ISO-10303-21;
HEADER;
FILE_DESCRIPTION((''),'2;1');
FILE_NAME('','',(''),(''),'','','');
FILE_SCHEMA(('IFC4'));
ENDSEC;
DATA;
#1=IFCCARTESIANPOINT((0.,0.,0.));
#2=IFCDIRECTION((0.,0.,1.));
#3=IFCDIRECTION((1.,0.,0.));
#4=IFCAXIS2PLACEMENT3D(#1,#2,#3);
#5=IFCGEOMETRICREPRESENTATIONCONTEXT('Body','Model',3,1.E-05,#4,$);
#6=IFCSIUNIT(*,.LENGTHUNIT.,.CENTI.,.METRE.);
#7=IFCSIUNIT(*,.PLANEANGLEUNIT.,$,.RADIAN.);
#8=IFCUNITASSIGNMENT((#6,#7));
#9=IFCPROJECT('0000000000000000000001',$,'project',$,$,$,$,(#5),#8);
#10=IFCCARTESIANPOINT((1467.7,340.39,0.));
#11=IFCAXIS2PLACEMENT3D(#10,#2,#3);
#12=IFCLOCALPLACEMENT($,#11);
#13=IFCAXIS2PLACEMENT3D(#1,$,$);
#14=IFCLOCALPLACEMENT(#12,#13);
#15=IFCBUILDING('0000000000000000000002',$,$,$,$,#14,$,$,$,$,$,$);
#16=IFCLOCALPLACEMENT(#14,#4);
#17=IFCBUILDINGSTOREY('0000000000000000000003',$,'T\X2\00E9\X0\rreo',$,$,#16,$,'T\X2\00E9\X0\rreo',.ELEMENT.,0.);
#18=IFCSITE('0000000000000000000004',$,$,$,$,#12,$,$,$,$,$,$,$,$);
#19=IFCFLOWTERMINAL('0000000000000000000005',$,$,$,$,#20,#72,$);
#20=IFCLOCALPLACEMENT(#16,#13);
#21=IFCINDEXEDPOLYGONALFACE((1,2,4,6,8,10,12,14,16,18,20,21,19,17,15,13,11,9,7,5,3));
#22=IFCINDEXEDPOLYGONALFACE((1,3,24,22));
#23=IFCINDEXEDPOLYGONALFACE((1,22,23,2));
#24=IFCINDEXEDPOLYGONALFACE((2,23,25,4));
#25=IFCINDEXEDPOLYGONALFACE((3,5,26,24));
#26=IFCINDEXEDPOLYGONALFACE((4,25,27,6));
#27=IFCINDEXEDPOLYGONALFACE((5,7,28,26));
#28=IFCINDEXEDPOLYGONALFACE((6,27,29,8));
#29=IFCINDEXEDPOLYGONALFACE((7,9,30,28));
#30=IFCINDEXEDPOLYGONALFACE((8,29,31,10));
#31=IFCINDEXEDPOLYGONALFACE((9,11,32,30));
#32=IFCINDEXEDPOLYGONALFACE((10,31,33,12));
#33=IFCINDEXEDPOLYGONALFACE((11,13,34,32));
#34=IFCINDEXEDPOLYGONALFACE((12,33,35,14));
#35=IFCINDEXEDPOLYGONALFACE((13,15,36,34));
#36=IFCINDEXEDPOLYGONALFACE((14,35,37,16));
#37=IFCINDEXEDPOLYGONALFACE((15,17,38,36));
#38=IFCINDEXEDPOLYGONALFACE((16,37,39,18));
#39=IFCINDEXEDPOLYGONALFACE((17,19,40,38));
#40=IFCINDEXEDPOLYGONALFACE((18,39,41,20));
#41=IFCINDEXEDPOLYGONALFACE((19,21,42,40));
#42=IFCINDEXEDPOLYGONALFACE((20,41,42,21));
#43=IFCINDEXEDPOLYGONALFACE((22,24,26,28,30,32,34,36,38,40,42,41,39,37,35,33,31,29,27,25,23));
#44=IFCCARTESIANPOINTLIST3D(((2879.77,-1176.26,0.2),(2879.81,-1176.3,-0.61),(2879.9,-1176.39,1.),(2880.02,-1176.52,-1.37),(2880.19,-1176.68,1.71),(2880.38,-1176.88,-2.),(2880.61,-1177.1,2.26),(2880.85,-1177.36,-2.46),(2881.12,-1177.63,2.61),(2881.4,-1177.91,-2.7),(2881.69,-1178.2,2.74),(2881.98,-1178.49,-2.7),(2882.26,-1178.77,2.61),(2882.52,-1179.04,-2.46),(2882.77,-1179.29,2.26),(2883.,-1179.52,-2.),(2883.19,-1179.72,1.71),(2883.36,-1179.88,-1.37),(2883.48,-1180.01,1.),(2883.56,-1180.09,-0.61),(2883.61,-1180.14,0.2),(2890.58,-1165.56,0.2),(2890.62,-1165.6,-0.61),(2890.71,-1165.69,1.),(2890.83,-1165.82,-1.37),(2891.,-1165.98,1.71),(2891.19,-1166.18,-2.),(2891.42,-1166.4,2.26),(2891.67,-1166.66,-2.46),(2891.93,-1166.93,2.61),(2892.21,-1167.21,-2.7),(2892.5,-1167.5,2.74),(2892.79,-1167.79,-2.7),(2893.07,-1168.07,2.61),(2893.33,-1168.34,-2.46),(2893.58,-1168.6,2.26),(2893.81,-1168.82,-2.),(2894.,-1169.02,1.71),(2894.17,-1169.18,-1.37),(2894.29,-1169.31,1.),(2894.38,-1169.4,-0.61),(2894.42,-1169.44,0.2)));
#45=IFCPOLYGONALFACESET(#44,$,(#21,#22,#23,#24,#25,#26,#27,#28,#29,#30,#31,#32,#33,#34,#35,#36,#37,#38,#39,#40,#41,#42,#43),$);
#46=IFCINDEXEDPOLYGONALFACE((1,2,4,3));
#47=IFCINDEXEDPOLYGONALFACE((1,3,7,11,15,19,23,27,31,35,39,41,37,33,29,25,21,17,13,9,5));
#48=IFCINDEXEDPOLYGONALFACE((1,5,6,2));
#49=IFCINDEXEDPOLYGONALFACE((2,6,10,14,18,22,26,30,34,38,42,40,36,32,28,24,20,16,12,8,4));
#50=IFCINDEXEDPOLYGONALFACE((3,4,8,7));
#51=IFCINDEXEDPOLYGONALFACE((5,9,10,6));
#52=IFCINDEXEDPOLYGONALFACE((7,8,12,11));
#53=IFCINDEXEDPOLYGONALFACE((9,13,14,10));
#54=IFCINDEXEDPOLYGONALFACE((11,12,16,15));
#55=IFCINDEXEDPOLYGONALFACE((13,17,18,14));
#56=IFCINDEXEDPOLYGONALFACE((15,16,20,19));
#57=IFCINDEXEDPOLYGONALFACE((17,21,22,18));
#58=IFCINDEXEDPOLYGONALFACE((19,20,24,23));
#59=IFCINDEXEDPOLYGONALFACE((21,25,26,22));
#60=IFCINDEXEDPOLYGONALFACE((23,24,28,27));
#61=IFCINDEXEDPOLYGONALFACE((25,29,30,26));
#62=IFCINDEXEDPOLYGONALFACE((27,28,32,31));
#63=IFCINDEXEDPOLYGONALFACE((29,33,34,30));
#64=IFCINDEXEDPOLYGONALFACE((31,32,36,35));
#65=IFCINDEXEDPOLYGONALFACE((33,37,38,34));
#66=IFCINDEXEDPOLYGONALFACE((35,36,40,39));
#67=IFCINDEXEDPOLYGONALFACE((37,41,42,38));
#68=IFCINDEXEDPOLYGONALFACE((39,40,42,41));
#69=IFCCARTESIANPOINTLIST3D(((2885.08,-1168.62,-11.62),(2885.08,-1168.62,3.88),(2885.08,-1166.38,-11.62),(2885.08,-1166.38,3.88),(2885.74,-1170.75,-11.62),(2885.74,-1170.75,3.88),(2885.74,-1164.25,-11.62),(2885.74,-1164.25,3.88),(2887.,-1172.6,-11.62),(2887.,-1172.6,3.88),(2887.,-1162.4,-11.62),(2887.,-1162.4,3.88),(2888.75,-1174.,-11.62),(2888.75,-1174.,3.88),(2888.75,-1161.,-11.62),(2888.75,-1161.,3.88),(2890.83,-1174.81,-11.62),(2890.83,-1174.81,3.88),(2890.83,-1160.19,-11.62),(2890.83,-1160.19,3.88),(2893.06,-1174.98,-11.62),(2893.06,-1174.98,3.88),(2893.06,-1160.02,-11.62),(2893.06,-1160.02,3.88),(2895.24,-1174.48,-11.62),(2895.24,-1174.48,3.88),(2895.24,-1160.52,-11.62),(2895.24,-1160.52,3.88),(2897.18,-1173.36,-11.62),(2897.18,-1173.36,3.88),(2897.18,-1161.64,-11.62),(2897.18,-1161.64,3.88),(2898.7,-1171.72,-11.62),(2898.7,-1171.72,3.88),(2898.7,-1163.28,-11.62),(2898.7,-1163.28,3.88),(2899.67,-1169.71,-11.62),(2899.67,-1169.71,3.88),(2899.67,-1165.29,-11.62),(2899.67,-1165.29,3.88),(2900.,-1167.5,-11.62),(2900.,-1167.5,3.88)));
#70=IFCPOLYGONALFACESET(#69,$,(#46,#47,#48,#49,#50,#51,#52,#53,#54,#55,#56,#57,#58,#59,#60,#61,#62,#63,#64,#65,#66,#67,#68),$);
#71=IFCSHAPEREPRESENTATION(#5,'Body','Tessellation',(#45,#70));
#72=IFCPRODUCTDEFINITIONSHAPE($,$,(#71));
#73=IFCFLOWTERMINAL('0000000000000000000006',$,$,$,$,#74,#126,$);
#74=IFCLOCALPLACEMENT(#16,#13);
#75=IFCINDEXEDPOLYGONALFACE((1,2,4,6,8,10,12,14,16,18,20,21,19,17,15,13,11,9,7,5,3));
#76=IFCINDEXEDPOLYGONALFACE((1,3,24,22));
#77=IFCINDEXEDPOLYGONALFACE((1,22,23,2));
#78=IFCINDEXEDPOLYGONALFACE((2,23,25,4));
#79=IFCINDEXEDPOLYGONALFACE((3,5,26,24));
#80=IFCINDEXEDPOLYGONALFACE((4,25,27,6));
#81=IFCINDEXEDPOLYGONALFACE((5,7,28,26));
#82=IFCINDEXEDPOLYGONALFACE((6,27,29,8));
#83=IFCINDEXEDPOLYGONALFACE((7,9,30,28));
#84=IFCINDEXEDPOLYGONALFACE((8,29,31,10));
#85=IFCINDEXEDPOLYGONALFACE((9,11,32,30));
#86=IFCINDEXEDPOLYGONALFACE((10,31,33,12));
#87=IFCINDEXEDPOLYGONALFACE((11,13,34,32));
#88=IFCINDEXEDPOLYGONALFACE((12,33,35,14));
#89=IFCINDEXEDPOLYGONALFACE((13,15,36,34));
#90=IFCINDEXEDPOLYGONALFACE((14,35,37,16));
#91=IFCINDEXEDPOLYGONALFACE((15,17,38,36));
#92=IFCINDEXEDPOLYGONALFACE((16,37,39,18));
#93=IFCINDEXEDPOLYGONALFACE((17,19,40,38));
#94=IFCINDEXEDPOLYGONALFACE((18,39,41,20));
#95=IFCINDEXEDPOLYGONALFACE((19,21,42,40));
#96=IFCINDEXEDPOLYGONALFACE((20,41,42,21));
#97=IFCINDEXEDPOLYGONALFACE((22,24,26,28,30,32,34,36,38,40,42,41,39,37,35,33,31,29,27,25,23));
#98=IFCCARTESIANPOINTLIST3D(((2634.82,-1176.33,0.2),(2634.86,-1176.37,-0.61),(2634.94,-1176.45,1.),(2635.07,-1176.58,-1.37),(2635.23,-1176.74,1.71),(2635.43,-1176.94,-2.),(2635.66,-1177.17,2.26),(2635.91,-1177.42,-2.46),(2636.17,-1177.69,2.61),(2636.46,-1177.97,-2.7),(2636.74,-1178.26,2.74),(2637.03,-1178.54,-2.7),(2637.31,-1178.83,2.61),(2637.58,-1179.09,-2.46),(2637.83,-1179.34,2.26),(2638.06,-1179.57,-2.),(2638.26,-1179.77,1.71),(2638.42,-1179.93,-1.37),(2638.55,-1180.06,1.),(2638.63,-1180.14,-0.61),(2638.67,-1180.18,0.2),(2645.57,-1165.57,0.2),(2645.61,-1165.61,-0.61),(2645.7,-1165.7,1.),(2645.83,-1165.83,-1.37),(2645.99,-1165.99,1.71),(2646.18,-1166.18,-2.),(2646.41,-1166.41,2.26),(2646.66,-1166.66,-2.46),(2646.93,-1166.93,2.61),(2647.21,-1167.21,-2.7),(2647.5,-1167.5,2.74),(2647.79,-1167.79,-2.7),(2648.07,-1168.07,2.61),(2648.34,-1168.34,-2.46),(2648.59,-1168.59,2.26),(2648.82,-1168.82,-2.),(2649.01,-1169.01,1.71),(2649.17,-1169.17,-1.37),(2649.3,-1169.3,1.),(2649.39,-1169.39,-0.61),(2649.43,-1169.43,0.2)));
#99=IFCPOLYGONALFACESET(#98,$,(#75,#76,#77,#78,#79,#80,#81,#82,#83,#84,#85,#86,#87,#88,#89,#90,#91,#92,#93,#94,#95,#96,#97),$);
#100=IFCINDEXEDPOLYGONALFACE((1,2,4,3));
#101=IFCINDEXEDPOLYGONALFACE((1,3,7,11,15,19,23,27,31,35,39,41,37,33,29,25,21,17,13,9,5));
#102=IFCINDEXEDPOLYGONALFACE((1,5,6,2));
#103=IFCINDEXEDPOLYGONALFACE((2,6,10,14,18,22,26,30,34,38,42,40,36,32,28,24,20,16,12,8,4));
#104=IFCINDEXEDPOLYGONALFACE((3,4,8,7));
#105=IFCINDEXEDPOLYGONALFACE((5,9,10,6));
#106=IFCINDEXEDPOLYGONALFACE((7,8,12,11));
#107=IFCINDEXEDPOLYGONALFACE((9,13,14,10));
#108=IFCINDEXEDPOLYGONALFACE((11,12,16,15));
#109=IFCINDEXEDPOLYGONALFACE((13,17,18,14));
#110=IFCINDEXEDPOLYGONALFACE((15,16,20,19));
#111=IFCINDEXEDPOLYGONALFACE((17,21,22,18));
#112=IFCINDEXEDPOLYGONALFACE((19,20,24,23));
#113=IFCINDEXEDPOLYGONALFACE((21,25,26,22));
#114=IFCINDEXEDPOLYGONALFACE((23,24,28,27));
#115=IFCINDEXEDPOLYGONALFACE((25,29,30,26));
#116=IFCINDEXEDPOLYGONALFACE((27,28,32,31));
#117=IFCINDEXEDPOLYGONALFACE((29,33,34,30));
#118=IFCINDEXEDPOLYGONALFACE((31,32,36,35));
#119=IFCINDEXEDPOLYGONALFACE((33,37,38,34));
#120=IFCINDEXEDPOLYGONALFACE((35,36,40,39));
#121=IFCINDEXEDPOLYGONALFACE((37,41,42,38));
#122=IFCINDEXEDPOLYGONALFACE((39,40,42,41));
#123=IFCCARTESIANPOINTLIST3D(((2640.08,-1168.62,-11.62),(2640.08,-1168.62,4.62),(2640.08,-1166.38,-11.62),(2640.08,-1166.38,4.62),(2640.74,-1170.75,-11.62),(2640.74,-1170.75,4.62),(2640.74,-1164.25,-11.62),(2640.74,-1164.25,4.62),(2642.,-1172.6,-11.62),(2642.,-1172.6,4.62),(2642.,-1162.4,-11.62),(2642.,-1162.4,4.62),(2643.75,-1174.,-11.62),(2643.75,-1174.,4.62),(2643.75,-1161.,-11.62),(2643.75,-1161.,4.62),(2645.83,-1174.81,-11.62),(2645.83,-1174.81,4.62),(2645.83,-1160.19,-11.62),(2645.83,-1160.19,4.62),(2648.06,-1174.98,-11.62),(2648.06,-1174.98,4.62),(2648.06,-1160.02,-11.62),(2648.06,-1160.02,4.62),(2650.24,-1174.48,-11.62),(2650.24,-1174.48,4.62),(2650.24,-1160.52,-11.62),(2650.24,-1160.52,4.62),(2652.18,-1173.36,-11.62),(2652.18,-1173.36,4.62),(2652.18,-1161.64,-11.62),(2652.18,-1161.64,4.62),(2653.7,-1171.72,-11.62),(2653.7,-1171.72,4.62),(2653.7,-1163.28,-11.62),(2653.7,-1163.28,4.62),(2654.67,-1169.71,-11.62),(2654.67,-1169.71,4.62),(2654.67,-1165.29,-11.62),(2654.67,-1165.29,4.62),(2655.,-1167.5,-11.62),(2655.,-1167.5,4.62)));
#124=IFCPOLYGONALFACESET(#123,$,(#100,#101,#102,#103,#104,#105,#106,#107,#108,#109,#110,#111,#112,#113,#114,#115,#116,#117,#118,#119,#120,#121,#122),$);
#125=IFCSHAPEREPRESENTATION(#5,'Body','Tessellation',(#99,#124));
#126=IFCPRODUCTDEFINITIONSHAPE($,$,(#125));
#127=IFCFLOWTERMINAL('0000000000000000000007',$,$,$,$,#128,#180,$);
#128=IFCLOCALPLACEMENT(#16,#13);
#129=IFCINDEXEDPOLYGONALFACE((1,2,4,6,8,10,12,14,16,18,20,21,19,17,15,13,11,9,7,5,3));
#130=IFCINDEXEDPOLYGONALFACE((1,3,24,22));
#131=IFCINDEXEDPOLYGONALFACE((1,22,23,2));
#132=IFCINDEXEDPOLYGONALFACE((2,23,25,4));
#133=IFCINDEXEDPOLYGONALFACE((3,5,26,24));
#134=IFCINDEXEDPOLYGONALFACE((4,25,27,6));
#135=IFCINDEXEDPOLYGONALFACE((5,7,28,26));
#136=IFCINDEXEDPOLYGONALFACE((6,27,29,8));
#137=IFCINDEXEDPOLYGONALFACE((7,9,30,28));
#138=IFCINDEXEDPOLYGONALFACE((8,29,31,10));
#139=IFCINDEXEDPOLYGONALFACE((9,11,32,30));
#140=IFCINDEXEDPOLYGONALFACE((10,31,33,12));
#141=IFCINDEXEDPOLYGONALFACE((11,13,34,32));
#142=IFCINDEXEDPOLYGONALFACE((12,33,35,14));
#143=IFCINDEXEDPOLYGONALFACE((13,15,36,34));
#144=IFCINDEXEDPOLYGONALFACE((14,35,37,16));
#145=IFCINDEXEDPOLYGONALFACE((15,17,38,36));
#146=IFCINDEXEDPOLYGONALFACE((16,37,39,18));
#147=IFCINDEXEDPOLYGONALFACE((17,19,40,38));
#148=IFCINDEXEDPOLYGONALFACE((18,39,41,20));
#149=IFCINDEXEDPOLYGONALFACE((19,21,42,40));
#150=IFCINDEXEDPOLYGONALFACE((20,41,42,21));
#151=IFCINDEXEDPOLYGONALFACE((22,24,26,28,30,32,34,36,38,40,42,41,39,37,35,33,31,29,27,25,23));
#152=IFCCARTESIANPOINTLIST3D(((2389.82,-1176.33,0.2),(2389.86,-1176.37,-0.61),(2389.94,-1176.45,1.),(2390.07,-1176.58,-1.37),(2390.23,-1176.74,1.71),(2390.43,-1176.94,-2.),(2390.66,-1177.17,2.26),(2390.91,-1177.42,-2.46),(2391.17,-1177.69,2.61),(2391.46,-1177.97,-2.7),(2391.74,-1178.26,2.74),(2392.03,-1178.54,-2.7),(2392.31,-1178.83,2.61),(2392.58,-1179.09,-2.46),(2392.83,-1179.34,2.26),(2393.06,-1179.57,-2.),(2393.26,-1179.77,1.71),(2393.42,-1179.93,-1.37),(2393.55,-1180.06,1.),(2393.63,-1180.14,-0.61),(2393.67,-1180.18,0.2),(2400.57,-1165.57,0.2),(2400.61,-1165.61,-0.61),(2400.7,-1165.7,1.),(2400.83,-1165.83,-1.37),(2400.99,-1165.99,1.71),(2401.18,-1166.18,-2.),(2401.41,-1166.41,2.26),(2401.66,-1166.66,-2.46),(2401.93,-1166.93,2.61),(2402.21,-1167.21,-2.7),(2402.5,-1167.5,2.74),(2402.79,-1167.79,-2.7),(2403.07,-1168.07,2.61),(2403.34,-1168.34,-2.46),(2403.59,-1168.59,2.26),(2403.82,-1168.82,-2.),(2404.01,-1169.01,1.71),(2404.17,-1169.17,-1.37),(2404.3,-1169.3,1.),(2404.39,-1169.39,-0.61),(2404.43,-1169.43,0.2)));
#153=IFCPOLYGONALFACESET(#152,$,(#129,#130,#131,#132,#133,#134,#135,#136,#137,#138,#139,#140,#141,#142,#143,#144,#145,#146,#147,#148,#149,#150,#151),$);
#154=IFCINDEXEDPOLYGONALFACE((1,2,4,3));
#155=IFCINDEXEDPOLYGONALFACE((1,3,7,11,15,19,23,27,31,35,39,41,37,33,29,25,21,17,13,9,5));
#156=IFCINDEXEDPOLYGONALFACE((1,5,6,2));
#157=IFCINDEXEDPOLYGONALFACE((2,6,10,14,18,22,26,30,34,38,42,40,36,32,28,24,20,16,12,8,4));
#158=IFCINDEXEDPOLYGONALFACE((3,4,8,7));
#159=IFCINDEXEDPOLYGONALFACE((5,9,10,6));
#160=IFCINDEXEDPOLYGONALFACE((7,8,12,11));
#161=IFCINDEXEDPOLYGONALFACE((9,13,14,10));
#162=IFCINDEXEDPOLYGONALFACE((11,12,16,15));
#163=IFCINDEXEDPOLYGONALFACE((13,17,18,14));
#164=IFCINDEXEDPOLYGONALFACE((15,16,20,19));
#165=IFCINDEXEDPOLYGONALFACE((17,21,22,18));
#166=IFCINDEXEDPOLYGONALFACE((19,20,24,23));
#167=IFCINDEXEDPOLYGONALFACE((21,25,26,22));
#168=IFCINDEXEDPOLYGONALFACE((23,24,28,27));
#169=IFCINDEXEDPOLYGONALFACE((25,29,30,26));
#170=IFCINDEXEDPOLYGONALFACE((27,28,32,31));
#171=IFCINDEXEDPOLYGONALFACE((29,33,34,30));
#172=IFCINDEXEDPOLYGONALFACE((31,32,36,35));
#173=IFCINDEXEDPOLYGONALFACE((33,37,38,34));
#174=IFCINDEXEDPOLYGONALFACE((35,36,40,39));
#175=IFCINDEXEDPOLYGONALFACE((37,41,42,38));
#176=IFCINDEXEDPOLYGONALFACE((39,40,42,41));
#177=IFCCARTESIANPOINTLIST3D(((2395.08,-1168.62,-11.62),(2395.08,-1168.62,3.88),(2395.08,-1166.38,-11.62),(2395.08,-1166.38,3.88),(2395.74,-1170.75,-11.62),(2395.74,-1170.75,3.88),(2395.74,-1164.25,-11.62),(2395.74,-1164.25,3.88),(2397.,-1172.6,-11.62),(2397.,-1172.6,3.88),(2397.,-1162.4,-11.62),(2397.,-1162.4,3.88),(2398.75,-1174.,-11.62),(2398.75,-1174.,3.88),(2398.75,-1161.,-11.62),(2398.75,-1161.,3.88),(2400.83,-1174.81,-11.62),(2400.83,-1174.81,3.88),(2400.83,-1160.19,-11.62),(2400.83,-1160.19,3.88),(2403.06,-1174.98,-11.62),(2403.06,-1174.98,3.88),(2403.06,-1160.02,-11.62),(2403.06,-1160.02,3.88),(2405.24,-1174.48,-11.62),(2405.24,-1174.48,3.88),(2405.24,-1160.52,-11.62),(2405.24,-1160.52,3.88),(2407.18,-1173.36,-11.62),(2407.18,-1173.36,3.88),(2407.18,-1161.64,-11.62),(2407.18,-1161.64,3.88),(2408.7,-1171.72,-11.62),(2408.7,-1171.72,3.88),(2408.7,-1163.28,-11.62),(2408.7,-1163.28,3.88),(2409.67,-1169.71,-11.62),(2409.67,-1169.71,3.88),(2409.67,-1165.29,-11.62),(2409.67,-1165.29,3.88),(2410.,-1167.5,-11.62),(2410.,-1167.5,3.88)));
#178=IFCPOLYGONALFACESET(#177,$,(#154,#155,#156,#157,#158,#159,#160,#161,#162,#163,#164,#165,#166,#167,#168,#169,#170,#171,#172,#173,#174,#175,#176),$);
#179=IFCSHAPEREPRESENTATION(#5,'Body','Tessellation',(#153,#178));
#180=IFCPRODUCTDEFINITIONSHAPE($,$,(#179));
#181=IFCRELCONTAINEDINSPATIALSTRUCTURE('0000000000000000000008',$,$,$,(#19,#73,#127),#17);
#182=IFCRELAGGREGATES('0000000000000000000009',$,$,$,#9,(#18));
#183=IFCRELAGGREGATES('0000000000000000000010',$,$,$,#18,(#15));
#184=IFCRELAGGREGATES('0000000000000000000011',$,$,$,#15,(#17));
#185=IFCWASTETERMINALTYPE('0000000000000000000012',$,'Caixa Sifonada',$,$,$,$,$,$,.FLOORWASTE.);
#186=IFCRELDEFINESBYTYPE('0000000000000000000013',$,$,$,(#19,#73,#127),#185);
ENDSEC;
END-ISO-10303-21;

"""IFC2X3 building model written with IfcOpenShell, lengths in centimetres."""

from ifc_helpers import new_model, si_unit, frame, origin, origin_with_axes, origin_2d_with_axis, place, context, project, spatial, circle, extrude, type_object, element, save


model = new_model("IFC2X3")

# Units and contexts
model_context = context("Model", 3, precision=1e-05, world=origin_with_axes(), identifier="Body")
ifc_project = project(units=[si_unit("LENGTHUNIT", "METRE", prefix="CENTI"), si_unit("PLANEANGLEUNIT", "RADIAN")], contexts=[model_context])

# Site, building, storey
site_placement = place(None, frame((1467.7, 340.39, 0.0), z_axis=(0.0, 0.0, 1.0), x_axis=(1.0, 0.0, 0.0)))
site = spatial("IfcSite", under=ifc_project, at=site_placement)
building_placement = place(site_placement, origin())
building = spatial("IfcBuilding", under=site, at=building_placement)
storey_placement = place(building_placement, origin_with_axes())
storey = spatial("IfcBuildingStorey", under=building, at=storey_placement, Name="Térreo", LongName="Térreo", CompositionType="ELEMENT", Elevation=0.0)

# Flow terminals
waste_terminal_type_1 = type_object("IfcWasteTerminalType", Name="Caixa Sifonada", PredefinedType="FLOORWASTE")
flow_terminal_1_placement = place(storey_placement, frame((2889.88, -1170.07, 3.88), z_axis=(0.0, 0.0, 1.0), x_axis=(1.0, 0.0, 0.0)))
element("IfcFlowTerminal", 1, at=flow_terminal_1_placement, inside=storey, type_object=waste_terminal_type_1, context=model_context, shape_type="SolidModel", body=[
    extrude(circle(Radius=2.73, at=origin_2d_with_axis()), frame((2.62, 2.57, -3.88), z_axis=(-0.71076, -0.703434, 0.0), x_axis=(0.0, 0.0, 1.0)), (0.0, 0.0, 1.0), 15.21),
    extrude(circle(Radius=7.5, at=origin_2d_with_axis()), frame((2.62, 2.57, -15.5), z_axis=(0.0, 0.0, 1.0), x_axis=(1.0, 0.0, 0.0)), (0.0, 0.0, 1.0), 15.5),
])
flow_terminal_2_placement = place(storey_placement, frame((2644.91, -1170.09, 4.62), z_axis=(0.0, 0.0, 1.0), x_axis=(1.0, 0.0, 0.0)))
element("IfcFlowTerminal", 2, at=flow_terminal_2_placement, inside=storey, type_object=waste_terminal_type_1, context=model_context, shape_type="SolidModel", body=[
    extrude(circle(Radius=2.73, at=origin_2d_with_axis()), frame((2.59, 2.59, -4.62), z_axis=(-0.707107, -0.707107, 0.0), x_axis=(0.0, 0.0, 1.0)), (0.0, 0.0, 1.0), 15.21),
    extrude(circle(Radius=7.5, at=origin_2d_with_axis()), frame((2.59, 2.59, -16.25), z_axis=(0.0, 0.0, 1.0), x_axis=(1.0, 0.0, 0.0)), (0.0, 0.0, 1.0), 16.25),
])
flow_terminal_3_placement = place(storey_placement, frame((2399.91, -1170.09, 3.88), z_axis=(0.0, 0.0, 1.0), x_axis=(1.0, 0.0, 0.0)))
element("IfcFlowTerminal", 3, at=flow_terminal_3_placement, inside=storey, type_object=waste_terminal_type_1, context=model_context, shape_type="SolidModel", body=[
    extrude(circle(Radius=2.73, at=origin_2d_with_axis()), frame((2.59, 2.59, -3.88), z_axis=(-0.707107, -0.707107, 0.0), x_axis=(0.0, 0.0, 1.0)), (0.0, 0.0, 1.0), 15.21),
    extrude(circle(Radius=7.5, at=origin_2d_with_axis()), frame((2.59, 2.59, -15.5), z_axis=(0.0, 0.0, 1.0), x_axis=(1.0, 0.0, 0.0)), (0.0, 0.0, 1.0), 15.5),
])

save(model, "model.ifc")
